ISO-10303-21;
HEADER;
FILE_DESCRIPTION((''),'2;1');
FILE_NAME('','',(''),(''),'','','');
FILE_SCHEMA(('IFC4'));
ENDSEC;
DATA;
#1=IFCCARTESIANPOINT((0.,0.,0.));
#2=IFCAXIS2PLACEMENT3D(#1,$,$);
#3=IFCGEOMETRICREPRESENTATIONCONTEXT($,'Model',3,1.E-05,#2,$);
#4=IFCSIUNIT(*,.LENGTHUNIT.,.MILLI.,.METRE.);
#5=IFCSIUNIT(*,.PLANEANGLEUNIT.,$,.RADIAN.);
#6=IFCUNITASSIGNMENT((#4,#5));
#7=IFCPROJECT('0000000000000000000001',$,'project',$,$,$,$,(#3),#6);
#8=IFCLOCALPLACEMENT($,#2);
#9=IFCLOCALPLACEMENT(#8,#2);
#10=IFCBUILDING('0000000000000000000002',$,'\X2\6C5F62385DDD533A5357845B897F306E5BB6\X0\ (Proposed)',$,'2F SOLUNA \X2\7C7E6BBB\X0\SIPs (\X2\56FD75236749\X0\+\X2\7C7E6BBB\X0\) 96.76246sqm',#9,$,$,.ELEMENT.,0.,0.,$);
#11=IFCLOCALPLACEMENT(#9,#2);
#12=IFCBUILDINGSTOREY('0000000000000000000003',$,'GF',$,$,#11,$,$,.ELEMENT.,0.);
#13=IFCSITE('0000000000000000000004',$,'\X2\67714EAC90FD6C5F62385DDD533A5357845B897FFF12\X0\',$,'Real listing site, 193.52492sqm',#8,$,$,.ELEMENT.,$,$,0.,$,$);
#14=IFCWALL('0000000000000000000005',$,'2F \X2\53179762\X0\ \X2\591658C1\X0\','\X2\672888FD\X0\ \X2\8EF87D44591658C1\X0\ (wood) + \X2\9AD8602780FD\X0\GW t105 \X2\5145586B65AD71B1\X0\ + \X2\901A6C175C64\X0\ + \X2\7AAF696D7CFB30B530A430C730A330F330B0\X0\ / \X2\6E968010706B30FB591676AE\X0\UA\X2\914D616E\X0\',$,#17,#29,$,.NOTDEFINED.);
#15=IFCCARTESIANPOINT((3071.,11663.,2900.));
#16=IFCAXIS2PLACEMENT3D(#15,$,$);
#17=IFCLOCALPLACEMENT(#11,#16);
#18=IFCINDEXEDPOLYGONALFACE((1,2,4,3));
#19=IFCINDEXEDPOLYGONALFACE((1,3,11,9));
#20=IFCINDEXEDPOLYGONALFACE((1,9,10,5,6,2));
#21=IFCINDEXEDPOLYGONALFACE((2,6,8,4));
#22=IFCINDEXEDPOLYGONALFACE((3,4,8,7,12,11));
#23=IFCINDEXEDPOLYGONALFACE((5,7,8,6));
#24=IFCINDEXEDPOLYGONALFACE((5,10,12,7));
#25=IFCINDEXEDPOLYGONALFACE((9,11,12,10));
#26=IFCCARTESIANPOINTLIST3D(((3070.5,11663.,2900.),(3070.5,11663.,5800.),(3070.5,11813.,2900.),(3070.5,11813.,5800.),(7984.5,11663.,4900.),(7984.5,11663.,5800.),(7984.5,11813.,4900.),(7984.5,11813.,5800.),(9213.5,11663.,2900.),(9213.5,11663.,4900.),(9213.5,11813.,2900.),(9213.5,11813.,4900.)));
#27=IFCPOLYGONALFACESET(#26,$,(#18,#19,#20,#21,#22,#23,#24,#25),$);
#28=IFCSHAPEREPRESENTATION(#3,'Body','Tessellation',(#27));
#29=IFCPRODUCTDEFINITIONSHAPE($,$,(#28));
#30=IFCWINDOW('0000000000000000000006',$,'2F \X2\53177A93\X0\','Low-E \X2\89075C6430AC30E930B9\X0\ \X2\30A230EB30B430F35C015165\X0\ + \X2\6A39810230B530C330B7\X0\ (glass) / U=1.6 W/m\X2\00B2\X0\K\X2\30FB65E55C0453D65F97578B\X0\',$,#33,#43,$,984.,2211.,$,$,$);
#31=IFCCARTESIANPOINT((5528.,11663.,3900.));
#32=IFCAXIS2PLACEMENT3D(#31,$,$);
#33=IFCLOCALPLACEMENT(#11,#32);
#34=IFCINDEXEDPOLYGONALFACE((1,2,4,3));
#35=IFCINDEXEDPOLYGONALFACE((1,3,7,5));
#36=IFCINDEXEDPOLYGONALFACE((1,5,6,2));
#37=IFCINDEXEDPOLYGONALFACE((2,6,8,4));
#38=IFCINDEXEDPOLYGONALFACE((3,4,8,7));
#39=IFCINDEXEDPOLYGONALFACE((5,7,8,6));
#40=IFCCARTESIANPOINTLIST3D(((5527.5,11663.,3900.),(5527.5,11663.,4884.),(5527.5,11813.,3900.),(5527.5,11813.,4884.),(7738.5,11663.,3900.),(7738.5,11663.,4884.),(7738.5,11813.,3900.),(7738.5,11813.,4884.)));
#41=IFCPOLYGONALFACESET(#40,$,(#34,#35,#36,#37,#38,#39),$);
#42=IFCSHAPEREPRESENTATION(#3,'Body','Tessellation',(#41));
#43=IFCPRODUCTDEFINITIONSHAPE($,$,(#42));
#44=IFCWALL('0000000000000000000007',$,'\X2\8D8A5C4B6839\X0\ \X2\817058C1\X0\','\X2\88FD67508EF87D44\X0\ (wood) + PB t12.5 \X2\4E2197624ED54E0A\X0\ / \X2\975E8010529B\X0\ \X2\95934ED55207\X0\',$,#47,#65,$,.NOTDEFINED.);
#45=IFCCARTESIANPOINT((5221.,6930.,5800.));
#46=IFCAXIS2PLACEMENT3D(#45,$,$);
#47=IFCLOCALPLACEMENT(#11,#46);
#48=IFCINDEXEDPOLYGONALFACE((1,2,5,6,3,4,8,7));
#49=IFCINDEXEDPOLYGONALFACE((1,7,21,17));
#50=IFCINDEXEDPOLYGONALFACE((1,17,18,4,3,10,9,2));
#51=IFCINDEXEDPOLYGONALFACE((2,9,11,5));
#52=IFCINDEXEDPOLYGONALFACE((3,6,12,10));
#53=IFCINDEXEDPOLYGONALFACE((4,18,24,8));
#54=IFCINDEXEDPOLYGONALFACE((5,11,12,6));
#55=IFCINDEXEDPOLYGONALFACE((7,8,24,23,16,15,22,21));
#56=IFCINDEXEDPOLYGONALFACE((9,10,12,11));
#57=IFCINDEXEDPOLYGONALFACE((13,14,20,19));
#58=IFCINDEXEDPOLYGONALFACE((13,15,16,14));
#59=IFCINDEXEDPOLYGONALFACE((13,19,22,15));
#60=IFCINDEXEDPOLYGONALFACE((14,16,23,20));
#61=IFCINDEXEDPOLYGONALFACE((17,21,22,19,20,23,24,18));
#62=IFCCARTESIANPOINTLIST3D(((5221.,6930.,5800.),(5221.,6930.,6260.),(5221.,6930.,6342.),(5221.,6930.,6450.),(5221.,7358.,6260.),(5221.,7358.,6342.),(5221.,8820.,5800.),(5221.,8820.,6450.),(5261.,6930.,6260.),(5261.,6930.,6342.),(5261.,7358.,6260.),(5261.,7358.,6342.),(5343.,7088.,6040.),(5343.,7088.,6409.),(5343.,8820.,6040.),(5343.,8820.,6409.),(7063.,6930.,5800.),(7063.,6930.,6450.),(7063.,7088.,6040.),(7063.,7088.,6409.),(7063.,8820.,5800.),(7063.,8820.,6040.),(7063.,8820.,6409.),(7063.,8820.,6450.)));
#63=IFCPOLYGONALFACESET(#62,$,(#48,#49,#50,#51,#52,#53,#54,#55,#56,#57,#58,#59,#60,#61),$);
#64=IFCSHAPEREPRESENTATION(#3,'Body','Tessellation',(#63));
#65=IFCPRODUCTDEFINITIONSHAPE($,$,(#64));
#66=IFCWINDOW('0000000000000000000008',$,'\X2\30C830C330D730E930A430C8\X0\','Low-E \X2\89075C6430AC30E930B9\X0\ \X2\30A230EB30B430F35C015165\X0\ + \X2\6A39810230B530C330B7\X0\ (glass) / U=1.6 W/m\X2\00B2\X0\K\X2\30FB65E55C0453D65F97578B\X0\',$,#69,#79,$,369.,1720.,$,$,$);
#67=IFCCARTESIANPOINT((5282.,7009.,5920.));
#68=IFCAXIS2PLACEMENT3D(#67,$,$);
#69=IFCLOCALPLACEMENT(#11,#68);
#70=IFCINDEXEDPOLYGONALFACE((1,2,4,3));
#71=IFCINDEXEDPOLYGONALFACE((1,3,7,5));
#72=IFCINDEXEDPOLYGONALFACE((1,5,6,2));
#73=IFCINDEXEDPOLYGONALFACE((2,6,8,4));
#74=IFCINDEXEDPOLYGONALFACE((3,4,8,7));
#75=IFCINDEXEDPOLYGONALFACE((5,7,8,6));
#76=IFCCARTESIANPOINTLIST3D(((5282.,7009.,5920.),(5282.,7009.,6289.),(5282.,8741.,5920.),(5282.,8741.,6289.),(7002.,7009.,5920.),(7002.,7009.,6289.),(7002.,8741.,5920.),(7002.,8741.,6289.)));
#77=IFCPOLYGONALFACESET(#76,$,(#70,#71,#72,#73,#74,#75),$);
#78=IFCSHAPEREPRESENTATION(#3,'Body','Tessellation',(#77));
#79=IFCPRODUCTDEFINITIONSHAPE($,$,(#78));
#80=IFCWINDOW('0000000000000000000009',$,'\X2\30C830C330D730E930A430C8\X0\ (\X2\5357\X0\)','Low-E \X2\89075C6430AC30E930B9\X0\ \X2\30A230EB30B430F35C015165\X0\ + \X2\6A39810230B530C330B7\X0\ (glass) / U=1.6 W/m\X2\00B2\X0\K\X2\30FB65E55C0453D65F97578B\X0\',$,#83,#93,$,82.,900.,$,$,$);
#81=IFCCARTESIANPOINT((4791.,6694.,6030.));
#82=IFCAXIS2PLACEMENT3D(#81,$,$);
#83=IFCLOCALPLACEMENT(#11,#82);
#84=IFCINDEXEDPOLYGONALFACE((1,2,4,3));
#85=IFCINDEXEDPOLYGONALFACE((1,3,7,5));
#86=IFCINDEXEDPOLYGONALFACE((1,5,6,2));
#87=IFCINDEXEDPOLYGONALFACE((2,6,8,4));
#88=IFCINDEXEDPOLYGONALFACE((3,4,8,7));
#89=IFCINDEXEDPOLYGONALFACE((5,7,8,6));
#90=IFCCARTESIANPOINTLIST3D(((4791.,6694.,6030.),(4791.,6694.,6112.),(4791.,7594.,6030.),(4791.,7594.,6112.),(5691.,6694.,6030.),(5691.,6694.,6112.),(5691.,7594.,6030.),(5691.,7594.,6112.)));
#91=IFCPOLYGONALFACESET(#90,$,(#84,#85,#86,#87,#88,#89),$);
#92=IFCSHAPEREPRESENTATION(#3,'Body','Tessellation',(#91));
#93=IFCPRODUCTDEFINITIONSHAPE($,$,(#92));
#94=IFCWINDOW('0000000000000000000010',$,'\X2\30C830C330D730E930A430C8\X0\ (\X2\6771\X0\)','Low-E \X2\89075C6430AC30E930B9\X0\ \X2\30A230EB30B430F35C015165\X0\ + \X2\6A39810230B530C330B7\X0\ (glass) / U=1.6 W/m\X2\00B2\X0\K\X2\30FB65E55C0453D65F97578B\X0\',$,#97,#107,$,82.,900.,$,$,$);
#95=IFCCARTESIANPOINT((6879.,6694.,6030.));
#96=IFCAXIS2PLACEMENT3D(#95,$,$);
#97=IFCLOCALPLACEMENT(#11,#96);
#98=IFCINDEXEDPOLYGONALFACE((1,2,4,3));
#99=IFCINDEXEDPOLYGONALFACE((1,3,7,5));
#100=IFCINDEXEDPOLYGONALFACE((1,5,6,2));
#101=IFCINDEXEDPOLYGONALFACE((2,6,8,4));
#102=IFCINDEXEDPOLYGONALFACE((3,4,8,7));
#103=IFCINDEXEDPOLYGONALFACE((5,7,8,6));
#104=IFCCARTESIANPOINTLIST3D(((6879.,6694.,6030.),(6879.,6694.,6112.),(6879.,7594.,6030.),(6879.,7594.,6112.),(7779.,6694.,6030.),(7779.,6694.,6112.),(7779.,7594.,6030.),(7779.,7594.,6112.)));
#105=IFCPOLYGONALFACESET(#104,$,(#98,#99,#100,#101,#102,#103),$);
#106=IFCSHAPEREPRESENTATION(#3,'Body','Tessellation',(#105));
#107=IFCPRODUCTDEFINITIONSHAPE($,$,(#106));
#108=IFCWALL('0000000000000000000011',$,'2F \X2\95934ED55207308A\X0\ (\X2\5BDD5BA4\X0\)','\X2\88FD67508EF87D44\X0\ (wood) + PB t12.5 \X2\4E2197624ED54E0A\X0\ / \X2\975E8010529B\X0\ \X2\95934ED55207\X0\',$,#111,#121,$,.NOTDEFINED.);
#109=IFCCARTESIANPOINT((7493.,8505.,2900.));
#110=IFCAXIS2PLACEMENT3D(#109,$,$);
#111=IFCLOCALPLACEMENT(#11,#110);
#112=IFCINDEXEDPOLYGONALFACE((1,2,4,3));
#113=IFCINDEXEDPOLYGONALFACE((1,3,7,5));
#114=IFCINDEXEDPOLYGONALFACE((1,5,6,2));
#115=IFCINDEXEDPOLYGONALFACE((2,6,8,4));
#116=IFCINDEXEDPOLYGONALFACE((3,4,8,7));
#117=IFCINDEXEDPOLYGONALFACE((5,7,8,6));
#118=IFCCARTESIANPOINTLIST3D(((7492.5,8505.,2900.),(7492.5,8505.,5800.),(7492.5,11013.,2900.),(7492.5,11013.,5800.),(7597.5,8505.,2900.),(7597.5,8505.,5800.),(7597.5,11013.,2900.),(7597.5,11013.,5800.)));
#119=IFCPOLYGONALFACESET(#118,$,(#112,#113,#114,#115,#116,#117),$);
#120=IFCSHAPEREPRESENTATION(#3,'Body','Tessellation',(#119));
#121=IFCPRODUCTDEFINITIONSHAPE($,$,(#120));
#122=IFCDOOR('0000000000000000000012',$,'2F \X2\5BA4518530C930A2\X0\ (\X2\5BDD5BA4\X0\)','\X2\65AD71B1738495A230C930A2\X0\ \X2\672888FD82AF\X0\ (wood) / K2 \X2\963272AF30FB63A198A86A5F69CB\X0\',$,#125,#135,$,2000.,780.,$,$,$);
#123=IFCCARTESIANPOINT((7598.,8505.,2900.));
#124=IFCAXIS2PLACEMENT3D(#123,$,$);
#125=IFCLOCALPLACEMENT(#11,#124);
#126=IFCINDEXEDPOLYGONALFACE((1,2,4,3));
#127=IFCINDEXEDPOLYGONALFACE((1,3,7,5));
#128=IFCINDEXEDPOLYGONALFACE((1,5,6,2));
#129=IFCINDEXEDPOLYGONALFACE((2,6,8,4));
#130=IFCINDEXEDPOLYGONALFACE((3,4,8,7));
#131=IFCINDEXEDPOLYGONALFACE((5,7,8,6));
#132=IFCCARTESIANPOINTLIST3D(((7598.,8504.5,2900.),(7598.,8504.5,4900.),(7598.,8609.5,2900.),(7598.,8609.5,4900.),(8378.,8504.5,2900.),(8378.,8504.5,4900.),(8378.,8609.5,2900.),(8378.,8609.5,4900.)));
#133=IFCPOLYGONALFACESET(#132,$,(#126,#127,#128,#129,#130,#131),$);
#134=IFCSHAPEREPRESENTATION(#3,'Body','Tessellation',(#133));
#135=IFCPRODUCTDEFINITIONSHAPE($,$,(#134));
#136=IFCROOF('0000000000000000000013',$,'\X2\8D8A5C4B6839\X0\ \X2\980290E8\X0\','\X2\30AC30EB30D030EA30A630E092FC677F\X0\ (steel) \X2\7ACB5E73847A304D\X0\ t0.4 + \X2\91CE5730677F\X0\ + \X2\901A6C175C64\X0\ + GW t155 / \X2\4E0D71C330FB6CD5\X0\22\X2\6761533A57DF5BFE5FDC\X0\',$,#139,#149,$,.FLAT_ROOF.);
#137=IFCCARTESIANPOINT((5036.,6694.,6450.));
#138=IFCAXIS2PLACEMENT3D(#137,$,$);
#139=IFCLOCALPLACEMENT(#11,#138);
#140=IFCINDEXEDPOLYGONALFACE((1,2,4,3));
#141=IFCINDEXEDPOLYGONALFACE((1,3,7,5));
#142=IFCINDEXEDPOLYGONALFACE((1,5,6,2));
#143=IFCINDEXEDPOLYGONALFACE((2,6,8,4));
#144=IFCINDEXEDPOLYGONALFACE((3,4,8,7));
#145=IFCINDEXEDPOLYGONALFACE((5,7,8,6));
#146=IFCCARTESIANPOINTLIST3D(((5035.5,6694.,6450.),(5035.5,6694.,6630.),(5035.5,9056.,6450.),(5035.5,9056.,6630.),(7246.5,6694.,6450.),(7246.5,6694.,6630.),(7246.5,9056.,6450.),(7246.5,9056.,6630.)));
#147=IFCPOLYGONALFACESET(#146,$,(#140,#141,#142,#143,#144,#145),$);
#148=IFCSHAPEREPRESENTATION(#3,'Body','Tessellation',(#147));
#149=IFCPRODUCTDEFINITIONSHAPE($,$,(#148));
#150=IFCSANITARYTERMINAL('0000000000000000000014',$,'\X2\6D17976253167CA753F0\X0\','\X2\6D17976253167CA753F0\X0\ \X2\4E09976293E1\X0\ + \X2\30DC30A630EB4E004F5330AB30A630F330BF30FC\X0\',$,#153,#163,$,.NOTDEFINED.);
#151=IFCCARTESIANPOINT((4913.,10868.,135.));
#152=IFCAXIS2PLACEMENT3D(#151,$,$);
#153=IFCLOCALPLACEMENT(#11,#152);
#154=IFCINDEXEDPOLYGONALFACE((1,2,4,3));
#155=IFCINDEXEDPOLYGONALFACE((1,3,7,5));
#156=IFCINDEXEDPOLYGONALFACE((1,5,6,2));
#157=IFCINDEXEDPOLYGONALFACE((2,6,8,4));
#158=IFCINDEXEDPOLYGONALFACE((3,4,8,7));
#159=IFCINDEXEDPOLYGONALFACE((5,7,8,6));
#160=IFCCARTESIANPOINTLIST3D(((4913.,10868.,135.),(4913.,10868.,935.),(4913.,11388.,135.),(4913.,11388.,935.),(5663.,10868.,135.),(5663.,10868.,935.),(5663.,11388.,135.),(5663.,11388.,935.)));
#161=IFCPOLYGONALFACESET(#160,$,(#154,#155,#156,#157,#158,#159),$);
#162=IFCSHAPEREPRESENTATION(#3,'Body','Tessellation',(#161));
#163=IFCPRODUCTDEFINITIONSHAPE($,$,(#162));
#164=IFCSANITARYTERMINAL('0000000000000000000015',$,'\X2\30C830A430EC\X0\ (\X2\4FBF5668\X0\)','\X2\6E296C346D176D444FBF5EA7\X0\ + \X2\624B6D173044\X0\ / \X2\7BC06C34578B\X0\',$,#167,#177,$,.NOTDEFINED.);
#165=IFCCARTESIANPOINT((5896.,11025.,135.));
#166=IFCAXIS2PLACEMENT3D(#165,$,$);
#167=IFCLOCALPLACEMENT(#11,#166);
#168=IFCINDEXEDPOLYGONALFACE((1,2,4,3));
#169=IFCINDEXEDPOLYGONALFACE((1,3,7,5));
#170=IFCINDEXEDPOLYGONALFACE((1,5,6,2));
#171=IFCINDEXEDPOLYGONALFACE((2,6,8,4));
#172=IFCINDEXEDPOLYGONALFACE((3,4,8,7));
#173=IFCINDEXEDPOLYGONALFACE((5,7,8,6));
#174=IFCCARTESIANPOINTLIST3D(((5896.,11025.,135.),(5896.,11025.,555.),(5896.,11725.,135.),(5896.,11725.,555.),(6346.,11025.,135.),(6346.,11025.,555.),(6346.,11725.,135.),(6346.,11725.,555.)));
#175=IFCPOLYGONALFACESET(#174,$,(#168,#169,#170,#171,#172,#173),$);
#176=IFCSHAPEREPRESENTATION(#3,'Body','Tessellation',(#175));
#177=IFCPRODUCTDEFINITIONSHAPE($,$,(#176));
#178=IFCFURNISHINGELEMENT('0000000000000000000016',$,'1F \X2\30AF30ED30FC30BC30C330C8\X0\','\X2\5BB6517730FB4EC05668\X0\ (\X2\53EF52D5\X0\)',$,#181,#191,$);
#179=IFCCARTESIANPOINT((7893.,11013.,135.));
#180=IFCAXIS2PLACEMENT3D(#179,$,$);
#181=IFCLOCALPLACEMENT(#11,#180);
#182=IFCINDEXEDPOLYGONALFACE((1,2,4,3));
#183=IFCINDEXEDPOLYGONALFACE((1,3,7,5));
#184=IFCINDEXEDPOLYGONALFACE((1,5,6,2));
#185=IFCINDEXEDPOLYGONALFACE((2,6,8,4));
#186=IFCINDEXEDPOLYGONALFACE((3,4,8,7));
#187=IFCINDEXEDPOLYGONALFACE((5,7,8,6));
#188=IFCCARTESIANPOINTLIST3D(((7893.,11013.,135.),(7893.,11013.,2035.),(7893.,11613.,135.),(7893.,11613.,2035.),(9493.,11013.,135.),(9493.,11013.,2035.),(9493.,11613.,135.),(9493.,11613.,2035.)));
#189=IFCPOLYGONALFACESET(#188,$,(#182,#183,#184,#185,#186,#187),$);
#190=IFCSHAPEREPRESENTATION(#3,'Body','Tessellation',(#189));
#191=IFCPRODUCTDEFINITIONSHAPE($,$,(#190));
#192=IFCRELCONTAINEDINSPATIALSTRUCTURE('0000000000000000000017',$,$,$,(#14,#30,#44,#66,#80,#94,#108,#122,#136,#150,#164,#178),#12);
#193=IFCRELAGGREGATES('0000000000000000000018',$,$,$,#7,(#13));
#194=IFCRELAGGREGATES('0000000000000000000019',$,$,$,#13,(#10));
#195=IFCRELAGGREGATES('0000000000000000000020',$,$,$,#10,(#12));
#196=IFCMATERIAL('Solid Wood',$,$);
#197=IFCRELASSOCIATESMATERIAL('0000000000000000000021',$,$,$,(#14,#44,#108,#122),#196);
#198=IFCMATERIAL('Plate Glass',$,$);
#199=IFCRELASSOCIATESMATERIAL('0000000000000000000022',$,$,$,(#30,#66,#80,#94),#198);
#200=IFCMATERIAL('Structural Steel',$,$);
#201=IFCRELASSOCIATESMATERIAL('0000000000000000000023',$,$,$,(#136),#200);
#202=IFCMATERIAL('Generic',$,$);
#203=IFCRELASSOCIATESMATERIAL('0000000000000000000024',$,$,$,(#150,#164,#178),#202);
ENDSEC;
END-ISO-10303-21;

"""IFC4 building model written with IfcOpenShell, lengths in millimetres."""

from ifc_helpers import new_model, si_unit, frame, frame_2d, origin, place, context, project, spatial, rectangle, extrude, material, element, fill, save


model = new_model("IFC4")

# Units and contexts
model_context = context("Model", 3, precision=1e-05, world=origin())
ifc_project = project(units=[si_unit("LENGTHUNIT", "METRE", prefix="MILLI"), si_unit("PLANEANGLEUNIT", "RADIAN")], contexts=[model_context])

# Site, building, storey
site_placement = place(None, origin())
site = spatial("IfcSite", under=ifc_project, at=site_placement, Name="東京都江戸川区南葛西２", ObjectType="Real listing site, 193.52492sqm", CompositionType="ELEMENT", RefElevation=0.0)
building_placement = place(site_placement, origin())
building = spatial("IfcBuilding", under=site, at=building_placement, Name="江戸川区南葛西の家 (Proposed)", ObjectType="2F SOLUNA 籾殻SIPs (国産杉+籾殻) 96.76246sqm", CompositionType="ELEMENT", ElevationOfRefHeight=0.0, ElevationOfTerrain=0.0)
storey_placement = place(building_placement, origin())
storey = spatial("IfcBuildingStorey", under=building, at=storey_placement, Name="GF", CompositionType="ELEMENT", Elevation=0.0)

# Wall, opening, window
ifc_material_1 = material(Name="Solid Wood")
wall_1_placement = place(storey_placement, frame((3071.0, 11663.0, 2900.0)))
wall_1 = element("IfcWall", 1, at=wall_1_placement, inside=storey, material=ifc_material_1, Name="2F 北面 外壁", Description="木製 軸組外壁 (wood) + 高性能GW t105 充填断熱 + 通気層 + 窯業系サイディング / 準耐火・外皮UA配慮", PredefinedType="NOTDEFINED", context=model_context, shape_type="SweptSolid", body=[
    extrude(rectangle(XDim=6143.0, YDim=150.0, at=frame_2d((3071.0, 75.0))), frame((3071.0, 11663.0, 2900.0)), (0.0, 0.0, 1.0), 2900.0),
])
opening_1_placement = place(storey_placement, frame((5528.0, 11663.0, 3900.0)))
opening_1 = element("IfcOpeningElement", 2, at=opening_1_placement, cuts=wall_1, PredefinedType="NOTDEFINED", context=model_context, shape_type="SweptSolid", body=[
    extrude(rectangle(XDim=2211.0, YDim=150.0, at=frame_2d((1105.0, 75.0))), frame((5528.0, 11663.0, 3900.0)), (0.0, 0.0, 1.0), 984.0),
])
ifc_material_2 = material(Name="Plate Glass")
window_1_placement = place(storey_placement, frame((5528.0, 11663.0, 3900.0)))
window_1 = element("IfcWindow", 3, at=window_1_placement, inside=storey, material=ifc_material_2, Name="2F 北窓", Description="Low-E 複層ガラス アルゴン封入 + 樹脂サッシ (glass) / U=1.6 W/m²K・日射取得型", OverallHeight=984.0, OverallWidth=2211.0, context=model_context, shape_type="SweptSolid", body=[
    extrude(rectangle(XDim=2211.0, YDim=150.0, at=frame_2d((1105.0, 75.0))), frame((5528.0, 11663.0, 3900.0)), (0.0, 0.0, 1.0), 984.0),
])
fill(opening_1, window_1)

# Wall, openings, windows
wall_2_placement = place(storey_placement, frame((5221.0, 6930.0, 5800.0)))
wall_2 = element("IfcWall", 4, at=wall_2_placement, inside=storey, material=ifc_material_1, Name="越屋根 腰壁", Description="製材軸組 (wood) + PB t12.5 両面仕上 / 非耐力 間仕切", PredefinedType="NOTDEFINED", context=model_context, shape_type="SweptSolid", body=[
    extrude(rectangle(XDim=1842.0, YDim=1890.0, at=frame_2d((921.0, 945.0))), frame((5221.0, 6930.0, 5800.0)), (0.0, 0.0, 1.0), 650.0),
])
opening_2_placement = place(storey_placement, frame((5282.0, 7009.0, 5920.0)))
opening_2 = element("IfcOpeningElement", 5, at=opening_2_placement, cuts=wall_2, PredefinedType="NOTDEFINED", context=model_context, shape_type="SweptSolid", body=[
    extrude(rectangle(XDim=1720.0, YDim=1732.0, at=frame_2d((860.0, 866.0))), frame((5282.0, 7009.0, 5920.0)), (0.0, 0.0, 1.0), 369.0),
])
opening_3_placement = place(storey_placement, frame((4791.0, 6694.0, 6030.0)))
opening_3 = element("IfcOpeningElement", 6, at=opening_3_placement, cuts=wall_2, PredefinedType="NOTDEFINED", context=model_context, shape_type="SweptSolid", body=[
    extrude(rectangle(XDim=900.0, YDim=900.0, at=frame_2d((450.0, 450.0))), frame((4791.0, 6694.0, 6030.0)), (0.0, 0.0, 1.0), 82.0),
])
opening_4_placement = place(storey_placement, frame((6879.0, 6694.0, 6030.0)))
opening_4 = element("IfcOpeningElement", 7, at=opening_4_placement, cuts=wall_2, PredefinedType="NOTDEFINED", context=model_context, shape_type="SweptSolid", body=[
    extrude(rectangle(XDim=900.0, YDim=900.0, at=frame_2d((450.0, 450.0))), frame((6879.0, 6694.0, 6030.0)), (0.0, 0.0, 1.0), 82.0),
])
window_2_placement = place(storey_placement, frame((5282.0, 7009.0, 5920.0)))
window_2 = element("IfcWindow", 8, at=window_2_placement, inside=storey, material=ifc_material_2, Name="トップライト", Description="Low-E 複層ガラス アルゴン封入 + 樹脂サッシ (glass) / U=1.6 W/m²K・日射取得型", OverallHeight=369.0, OverallWidth=1720.0, context=model_context, shape_type="SweptSolid", body=[
    extrude(rectangle(XDim=1720.0, YDim=1732.0, at=frame_2d((860.0, 866.0))), frame((5282.0, 7009.0, 5920.0)), (0.0, 0.0, 1.0), 369.0),
])
fill(opening_2, window_2)
window_3_placement = place(storey_placement, frame((4791.0, 6694.0, 6030.0)))
window_3 = element("IfcWindow", 9, at=window_3_placement, inside=storey, material=ifc_material_2, Name="トップライト (南)", Description="Low-E 複層ガラス アルゴン封入 + 樹脂サッシ (glass) / U=1.6 W/m²K・日射取得型", OverallHeight=82.0, OverallWidth=900.0, context=model_context, shape_type="SweptSolid", body=[
    extrude(rectangle(XDim=900.0, YDim=900.0, at=frame_2d((450.0, 450.0))), frame((4791.0, 6694.0, 6030.0)), (0.0, 0.0, 1.0), 82.0),
])
fill(opening_3, window_3)
window_4_placement = place(storey_placement, frame((6879.0, 6694.0, 6030.0)))
window_4 = element("IfcWindow", 10, at=window_4_placement, inside=storey, material=ifc_material_2, Name="トップライト (東)", Description="Low-E 複層ガラス アルゴン封入 + 樹脂サッシ (glass) / U=1.6 W/m²K・日射取得型", OverallHeight=82.0, OverallWidth=900.0, context=model_context, shape_type="SweptSolid", body=[
    extrude(rectangle(XDim=900.0, YDim=900.0, at=frame_2d((450.0, 450.0))), frame((6879.0, 6694.0, 6030.0)), (0.0, 0.0, 1.0), 82.0),
])
fill(opening_4, window_4)

# Wall
wall_3_placement = place(storey_placement, frame((7493.0, 8505.0, 2900.0)))
element("IfcWall", 11, at=wall_3_placement, inside=storey, material=ifc_material_1, Name="2F 間仕切り (寝室)", Description="製材軸組 (wood) + PB t12.5 両面仕上 / 非耐力 間仕切", PredefinedType="NOTDEFINED", context=model_context, shape_type="SweptSolid", body=[
    extrude(rectangle(XDim=105.0, YDim=2508.0, at=frame_2d((52.0, 1254.0))), frame((7493.0, 8505.0, 2900.0)), (0.0, 0.0, 1.0), 2900.0),
])

# Door
door_placement = place(storey_placement, frame((7598.0, 8505.0, 2900.0)))
element("IfcDoor", 12, at=door_placement, inside=storey, material=ifc_material_1, Name="2F 室内ドア (寝室)", Description="断熱玄関ドア 木製芯 (wood) / K2 防犯・採風機構", OverallHeight=2000.0, OverallWidth=780.0, context=model_context, shape_type="SweptSolid", body=[
    extrude(rectangle(XDim=780.0, YDim=105.0, at=frame_2d((390.0, 52.0))), frame((7598.0, 8505.0, 2900.0)), (0.0, 0.0, 1.0), 2000.0),
])

# Roof
ifc_material_3 = material(Name="Structural Steel")
roof_placement = place(storey_placement, frame((5036.0, 6694.0, 6450.0)))
element("IfcRoof", 13, at=roof_placement, inside=storey, material=ifc_material_3, Name="越屋根 頂部", Description="ガルバリウム鋼板 (steel) 立平葺き t0.4 + 野地板 + 通気層 + GW t155 / 不燃・法22条区域対応", PredefinedType="FLAT_ROOF", context=model_context, shape_type="SweptSolid", body=[
    extrude(rectangle(XDim=2211.0, YDim=2362.0, at=frame_2d((1105.0, 1181.0))), frame((5036.0, 6694.0, 6450.0)), (0.0, 0.0, 1.0), 180.0),
])

# Sanitary terminals
ifc_material_4 = material(Name="Generic")
sanitary_terminal_1_placement = place(storey_placement, frame((4913.0, 10868.0, 135.0)))
element("IfcSanitaryTerminal", 14, at=sanitary_terminal_1_placement, inside=storey, material=ifc_material_4, Name="洗面化粧台", Description="洗面化粧台 三面鏡 + ボウル一体カウンター", PredefinedType="NOTDEFINED", context=model_context, shape_type="SweptSolid", body=[
    extrude(rectangle(XDim=750.0, YDim=520.0, at=frame_2d((375.0, 260.0))), frame((4913.0, 10868.0, 135.0)), (0.0, 0.0, 1.0), 800.0),
])
sanitary_terminal_2_placement = place(storey_placement, frame((5896.0, 11025.0, 135.0)))
element("IfcSanitaryTerminal", 15, at=sanitary_terminal_2_placement, inside=storey, material=ifc_material_4, Name="トイレ (便器)", Description="温水洗浄便座 + 手洗い / 節水型", PredefinedType="NOTDEFINED", context=model_context, shape_type="SweptSolid", body=[
    extrude(rectangle(XDim=450.0, YDim=700.0, at=frame_2d((225.0, 350.0))), frame((5896.0, 11025.0, 135.0)), (0.0, 0.0, 1.0), 420.0),
])

# Furnishing element
furnishing_1_placement = place(storey_placement, frame((7893.0, 11013.0, 135.0)))
element("IfcFurnishingElement", 16, at=furnishing_1_placement, inside=storey, material=ifc_material_4, Name="1F クローゼット", Description="家具・什器 (可動)", context=model_context, shape_type="SweptSolid", body=[
    extrude(rectangle(XDim=1600.0, YDim=600.0, at=frame_2d((800.0, 300.0))), frame((7893.0, 11013.0, 135.0)), (0.0, 0.0, 1.0), 1900.0),
])

save(model, "model.ifc")
